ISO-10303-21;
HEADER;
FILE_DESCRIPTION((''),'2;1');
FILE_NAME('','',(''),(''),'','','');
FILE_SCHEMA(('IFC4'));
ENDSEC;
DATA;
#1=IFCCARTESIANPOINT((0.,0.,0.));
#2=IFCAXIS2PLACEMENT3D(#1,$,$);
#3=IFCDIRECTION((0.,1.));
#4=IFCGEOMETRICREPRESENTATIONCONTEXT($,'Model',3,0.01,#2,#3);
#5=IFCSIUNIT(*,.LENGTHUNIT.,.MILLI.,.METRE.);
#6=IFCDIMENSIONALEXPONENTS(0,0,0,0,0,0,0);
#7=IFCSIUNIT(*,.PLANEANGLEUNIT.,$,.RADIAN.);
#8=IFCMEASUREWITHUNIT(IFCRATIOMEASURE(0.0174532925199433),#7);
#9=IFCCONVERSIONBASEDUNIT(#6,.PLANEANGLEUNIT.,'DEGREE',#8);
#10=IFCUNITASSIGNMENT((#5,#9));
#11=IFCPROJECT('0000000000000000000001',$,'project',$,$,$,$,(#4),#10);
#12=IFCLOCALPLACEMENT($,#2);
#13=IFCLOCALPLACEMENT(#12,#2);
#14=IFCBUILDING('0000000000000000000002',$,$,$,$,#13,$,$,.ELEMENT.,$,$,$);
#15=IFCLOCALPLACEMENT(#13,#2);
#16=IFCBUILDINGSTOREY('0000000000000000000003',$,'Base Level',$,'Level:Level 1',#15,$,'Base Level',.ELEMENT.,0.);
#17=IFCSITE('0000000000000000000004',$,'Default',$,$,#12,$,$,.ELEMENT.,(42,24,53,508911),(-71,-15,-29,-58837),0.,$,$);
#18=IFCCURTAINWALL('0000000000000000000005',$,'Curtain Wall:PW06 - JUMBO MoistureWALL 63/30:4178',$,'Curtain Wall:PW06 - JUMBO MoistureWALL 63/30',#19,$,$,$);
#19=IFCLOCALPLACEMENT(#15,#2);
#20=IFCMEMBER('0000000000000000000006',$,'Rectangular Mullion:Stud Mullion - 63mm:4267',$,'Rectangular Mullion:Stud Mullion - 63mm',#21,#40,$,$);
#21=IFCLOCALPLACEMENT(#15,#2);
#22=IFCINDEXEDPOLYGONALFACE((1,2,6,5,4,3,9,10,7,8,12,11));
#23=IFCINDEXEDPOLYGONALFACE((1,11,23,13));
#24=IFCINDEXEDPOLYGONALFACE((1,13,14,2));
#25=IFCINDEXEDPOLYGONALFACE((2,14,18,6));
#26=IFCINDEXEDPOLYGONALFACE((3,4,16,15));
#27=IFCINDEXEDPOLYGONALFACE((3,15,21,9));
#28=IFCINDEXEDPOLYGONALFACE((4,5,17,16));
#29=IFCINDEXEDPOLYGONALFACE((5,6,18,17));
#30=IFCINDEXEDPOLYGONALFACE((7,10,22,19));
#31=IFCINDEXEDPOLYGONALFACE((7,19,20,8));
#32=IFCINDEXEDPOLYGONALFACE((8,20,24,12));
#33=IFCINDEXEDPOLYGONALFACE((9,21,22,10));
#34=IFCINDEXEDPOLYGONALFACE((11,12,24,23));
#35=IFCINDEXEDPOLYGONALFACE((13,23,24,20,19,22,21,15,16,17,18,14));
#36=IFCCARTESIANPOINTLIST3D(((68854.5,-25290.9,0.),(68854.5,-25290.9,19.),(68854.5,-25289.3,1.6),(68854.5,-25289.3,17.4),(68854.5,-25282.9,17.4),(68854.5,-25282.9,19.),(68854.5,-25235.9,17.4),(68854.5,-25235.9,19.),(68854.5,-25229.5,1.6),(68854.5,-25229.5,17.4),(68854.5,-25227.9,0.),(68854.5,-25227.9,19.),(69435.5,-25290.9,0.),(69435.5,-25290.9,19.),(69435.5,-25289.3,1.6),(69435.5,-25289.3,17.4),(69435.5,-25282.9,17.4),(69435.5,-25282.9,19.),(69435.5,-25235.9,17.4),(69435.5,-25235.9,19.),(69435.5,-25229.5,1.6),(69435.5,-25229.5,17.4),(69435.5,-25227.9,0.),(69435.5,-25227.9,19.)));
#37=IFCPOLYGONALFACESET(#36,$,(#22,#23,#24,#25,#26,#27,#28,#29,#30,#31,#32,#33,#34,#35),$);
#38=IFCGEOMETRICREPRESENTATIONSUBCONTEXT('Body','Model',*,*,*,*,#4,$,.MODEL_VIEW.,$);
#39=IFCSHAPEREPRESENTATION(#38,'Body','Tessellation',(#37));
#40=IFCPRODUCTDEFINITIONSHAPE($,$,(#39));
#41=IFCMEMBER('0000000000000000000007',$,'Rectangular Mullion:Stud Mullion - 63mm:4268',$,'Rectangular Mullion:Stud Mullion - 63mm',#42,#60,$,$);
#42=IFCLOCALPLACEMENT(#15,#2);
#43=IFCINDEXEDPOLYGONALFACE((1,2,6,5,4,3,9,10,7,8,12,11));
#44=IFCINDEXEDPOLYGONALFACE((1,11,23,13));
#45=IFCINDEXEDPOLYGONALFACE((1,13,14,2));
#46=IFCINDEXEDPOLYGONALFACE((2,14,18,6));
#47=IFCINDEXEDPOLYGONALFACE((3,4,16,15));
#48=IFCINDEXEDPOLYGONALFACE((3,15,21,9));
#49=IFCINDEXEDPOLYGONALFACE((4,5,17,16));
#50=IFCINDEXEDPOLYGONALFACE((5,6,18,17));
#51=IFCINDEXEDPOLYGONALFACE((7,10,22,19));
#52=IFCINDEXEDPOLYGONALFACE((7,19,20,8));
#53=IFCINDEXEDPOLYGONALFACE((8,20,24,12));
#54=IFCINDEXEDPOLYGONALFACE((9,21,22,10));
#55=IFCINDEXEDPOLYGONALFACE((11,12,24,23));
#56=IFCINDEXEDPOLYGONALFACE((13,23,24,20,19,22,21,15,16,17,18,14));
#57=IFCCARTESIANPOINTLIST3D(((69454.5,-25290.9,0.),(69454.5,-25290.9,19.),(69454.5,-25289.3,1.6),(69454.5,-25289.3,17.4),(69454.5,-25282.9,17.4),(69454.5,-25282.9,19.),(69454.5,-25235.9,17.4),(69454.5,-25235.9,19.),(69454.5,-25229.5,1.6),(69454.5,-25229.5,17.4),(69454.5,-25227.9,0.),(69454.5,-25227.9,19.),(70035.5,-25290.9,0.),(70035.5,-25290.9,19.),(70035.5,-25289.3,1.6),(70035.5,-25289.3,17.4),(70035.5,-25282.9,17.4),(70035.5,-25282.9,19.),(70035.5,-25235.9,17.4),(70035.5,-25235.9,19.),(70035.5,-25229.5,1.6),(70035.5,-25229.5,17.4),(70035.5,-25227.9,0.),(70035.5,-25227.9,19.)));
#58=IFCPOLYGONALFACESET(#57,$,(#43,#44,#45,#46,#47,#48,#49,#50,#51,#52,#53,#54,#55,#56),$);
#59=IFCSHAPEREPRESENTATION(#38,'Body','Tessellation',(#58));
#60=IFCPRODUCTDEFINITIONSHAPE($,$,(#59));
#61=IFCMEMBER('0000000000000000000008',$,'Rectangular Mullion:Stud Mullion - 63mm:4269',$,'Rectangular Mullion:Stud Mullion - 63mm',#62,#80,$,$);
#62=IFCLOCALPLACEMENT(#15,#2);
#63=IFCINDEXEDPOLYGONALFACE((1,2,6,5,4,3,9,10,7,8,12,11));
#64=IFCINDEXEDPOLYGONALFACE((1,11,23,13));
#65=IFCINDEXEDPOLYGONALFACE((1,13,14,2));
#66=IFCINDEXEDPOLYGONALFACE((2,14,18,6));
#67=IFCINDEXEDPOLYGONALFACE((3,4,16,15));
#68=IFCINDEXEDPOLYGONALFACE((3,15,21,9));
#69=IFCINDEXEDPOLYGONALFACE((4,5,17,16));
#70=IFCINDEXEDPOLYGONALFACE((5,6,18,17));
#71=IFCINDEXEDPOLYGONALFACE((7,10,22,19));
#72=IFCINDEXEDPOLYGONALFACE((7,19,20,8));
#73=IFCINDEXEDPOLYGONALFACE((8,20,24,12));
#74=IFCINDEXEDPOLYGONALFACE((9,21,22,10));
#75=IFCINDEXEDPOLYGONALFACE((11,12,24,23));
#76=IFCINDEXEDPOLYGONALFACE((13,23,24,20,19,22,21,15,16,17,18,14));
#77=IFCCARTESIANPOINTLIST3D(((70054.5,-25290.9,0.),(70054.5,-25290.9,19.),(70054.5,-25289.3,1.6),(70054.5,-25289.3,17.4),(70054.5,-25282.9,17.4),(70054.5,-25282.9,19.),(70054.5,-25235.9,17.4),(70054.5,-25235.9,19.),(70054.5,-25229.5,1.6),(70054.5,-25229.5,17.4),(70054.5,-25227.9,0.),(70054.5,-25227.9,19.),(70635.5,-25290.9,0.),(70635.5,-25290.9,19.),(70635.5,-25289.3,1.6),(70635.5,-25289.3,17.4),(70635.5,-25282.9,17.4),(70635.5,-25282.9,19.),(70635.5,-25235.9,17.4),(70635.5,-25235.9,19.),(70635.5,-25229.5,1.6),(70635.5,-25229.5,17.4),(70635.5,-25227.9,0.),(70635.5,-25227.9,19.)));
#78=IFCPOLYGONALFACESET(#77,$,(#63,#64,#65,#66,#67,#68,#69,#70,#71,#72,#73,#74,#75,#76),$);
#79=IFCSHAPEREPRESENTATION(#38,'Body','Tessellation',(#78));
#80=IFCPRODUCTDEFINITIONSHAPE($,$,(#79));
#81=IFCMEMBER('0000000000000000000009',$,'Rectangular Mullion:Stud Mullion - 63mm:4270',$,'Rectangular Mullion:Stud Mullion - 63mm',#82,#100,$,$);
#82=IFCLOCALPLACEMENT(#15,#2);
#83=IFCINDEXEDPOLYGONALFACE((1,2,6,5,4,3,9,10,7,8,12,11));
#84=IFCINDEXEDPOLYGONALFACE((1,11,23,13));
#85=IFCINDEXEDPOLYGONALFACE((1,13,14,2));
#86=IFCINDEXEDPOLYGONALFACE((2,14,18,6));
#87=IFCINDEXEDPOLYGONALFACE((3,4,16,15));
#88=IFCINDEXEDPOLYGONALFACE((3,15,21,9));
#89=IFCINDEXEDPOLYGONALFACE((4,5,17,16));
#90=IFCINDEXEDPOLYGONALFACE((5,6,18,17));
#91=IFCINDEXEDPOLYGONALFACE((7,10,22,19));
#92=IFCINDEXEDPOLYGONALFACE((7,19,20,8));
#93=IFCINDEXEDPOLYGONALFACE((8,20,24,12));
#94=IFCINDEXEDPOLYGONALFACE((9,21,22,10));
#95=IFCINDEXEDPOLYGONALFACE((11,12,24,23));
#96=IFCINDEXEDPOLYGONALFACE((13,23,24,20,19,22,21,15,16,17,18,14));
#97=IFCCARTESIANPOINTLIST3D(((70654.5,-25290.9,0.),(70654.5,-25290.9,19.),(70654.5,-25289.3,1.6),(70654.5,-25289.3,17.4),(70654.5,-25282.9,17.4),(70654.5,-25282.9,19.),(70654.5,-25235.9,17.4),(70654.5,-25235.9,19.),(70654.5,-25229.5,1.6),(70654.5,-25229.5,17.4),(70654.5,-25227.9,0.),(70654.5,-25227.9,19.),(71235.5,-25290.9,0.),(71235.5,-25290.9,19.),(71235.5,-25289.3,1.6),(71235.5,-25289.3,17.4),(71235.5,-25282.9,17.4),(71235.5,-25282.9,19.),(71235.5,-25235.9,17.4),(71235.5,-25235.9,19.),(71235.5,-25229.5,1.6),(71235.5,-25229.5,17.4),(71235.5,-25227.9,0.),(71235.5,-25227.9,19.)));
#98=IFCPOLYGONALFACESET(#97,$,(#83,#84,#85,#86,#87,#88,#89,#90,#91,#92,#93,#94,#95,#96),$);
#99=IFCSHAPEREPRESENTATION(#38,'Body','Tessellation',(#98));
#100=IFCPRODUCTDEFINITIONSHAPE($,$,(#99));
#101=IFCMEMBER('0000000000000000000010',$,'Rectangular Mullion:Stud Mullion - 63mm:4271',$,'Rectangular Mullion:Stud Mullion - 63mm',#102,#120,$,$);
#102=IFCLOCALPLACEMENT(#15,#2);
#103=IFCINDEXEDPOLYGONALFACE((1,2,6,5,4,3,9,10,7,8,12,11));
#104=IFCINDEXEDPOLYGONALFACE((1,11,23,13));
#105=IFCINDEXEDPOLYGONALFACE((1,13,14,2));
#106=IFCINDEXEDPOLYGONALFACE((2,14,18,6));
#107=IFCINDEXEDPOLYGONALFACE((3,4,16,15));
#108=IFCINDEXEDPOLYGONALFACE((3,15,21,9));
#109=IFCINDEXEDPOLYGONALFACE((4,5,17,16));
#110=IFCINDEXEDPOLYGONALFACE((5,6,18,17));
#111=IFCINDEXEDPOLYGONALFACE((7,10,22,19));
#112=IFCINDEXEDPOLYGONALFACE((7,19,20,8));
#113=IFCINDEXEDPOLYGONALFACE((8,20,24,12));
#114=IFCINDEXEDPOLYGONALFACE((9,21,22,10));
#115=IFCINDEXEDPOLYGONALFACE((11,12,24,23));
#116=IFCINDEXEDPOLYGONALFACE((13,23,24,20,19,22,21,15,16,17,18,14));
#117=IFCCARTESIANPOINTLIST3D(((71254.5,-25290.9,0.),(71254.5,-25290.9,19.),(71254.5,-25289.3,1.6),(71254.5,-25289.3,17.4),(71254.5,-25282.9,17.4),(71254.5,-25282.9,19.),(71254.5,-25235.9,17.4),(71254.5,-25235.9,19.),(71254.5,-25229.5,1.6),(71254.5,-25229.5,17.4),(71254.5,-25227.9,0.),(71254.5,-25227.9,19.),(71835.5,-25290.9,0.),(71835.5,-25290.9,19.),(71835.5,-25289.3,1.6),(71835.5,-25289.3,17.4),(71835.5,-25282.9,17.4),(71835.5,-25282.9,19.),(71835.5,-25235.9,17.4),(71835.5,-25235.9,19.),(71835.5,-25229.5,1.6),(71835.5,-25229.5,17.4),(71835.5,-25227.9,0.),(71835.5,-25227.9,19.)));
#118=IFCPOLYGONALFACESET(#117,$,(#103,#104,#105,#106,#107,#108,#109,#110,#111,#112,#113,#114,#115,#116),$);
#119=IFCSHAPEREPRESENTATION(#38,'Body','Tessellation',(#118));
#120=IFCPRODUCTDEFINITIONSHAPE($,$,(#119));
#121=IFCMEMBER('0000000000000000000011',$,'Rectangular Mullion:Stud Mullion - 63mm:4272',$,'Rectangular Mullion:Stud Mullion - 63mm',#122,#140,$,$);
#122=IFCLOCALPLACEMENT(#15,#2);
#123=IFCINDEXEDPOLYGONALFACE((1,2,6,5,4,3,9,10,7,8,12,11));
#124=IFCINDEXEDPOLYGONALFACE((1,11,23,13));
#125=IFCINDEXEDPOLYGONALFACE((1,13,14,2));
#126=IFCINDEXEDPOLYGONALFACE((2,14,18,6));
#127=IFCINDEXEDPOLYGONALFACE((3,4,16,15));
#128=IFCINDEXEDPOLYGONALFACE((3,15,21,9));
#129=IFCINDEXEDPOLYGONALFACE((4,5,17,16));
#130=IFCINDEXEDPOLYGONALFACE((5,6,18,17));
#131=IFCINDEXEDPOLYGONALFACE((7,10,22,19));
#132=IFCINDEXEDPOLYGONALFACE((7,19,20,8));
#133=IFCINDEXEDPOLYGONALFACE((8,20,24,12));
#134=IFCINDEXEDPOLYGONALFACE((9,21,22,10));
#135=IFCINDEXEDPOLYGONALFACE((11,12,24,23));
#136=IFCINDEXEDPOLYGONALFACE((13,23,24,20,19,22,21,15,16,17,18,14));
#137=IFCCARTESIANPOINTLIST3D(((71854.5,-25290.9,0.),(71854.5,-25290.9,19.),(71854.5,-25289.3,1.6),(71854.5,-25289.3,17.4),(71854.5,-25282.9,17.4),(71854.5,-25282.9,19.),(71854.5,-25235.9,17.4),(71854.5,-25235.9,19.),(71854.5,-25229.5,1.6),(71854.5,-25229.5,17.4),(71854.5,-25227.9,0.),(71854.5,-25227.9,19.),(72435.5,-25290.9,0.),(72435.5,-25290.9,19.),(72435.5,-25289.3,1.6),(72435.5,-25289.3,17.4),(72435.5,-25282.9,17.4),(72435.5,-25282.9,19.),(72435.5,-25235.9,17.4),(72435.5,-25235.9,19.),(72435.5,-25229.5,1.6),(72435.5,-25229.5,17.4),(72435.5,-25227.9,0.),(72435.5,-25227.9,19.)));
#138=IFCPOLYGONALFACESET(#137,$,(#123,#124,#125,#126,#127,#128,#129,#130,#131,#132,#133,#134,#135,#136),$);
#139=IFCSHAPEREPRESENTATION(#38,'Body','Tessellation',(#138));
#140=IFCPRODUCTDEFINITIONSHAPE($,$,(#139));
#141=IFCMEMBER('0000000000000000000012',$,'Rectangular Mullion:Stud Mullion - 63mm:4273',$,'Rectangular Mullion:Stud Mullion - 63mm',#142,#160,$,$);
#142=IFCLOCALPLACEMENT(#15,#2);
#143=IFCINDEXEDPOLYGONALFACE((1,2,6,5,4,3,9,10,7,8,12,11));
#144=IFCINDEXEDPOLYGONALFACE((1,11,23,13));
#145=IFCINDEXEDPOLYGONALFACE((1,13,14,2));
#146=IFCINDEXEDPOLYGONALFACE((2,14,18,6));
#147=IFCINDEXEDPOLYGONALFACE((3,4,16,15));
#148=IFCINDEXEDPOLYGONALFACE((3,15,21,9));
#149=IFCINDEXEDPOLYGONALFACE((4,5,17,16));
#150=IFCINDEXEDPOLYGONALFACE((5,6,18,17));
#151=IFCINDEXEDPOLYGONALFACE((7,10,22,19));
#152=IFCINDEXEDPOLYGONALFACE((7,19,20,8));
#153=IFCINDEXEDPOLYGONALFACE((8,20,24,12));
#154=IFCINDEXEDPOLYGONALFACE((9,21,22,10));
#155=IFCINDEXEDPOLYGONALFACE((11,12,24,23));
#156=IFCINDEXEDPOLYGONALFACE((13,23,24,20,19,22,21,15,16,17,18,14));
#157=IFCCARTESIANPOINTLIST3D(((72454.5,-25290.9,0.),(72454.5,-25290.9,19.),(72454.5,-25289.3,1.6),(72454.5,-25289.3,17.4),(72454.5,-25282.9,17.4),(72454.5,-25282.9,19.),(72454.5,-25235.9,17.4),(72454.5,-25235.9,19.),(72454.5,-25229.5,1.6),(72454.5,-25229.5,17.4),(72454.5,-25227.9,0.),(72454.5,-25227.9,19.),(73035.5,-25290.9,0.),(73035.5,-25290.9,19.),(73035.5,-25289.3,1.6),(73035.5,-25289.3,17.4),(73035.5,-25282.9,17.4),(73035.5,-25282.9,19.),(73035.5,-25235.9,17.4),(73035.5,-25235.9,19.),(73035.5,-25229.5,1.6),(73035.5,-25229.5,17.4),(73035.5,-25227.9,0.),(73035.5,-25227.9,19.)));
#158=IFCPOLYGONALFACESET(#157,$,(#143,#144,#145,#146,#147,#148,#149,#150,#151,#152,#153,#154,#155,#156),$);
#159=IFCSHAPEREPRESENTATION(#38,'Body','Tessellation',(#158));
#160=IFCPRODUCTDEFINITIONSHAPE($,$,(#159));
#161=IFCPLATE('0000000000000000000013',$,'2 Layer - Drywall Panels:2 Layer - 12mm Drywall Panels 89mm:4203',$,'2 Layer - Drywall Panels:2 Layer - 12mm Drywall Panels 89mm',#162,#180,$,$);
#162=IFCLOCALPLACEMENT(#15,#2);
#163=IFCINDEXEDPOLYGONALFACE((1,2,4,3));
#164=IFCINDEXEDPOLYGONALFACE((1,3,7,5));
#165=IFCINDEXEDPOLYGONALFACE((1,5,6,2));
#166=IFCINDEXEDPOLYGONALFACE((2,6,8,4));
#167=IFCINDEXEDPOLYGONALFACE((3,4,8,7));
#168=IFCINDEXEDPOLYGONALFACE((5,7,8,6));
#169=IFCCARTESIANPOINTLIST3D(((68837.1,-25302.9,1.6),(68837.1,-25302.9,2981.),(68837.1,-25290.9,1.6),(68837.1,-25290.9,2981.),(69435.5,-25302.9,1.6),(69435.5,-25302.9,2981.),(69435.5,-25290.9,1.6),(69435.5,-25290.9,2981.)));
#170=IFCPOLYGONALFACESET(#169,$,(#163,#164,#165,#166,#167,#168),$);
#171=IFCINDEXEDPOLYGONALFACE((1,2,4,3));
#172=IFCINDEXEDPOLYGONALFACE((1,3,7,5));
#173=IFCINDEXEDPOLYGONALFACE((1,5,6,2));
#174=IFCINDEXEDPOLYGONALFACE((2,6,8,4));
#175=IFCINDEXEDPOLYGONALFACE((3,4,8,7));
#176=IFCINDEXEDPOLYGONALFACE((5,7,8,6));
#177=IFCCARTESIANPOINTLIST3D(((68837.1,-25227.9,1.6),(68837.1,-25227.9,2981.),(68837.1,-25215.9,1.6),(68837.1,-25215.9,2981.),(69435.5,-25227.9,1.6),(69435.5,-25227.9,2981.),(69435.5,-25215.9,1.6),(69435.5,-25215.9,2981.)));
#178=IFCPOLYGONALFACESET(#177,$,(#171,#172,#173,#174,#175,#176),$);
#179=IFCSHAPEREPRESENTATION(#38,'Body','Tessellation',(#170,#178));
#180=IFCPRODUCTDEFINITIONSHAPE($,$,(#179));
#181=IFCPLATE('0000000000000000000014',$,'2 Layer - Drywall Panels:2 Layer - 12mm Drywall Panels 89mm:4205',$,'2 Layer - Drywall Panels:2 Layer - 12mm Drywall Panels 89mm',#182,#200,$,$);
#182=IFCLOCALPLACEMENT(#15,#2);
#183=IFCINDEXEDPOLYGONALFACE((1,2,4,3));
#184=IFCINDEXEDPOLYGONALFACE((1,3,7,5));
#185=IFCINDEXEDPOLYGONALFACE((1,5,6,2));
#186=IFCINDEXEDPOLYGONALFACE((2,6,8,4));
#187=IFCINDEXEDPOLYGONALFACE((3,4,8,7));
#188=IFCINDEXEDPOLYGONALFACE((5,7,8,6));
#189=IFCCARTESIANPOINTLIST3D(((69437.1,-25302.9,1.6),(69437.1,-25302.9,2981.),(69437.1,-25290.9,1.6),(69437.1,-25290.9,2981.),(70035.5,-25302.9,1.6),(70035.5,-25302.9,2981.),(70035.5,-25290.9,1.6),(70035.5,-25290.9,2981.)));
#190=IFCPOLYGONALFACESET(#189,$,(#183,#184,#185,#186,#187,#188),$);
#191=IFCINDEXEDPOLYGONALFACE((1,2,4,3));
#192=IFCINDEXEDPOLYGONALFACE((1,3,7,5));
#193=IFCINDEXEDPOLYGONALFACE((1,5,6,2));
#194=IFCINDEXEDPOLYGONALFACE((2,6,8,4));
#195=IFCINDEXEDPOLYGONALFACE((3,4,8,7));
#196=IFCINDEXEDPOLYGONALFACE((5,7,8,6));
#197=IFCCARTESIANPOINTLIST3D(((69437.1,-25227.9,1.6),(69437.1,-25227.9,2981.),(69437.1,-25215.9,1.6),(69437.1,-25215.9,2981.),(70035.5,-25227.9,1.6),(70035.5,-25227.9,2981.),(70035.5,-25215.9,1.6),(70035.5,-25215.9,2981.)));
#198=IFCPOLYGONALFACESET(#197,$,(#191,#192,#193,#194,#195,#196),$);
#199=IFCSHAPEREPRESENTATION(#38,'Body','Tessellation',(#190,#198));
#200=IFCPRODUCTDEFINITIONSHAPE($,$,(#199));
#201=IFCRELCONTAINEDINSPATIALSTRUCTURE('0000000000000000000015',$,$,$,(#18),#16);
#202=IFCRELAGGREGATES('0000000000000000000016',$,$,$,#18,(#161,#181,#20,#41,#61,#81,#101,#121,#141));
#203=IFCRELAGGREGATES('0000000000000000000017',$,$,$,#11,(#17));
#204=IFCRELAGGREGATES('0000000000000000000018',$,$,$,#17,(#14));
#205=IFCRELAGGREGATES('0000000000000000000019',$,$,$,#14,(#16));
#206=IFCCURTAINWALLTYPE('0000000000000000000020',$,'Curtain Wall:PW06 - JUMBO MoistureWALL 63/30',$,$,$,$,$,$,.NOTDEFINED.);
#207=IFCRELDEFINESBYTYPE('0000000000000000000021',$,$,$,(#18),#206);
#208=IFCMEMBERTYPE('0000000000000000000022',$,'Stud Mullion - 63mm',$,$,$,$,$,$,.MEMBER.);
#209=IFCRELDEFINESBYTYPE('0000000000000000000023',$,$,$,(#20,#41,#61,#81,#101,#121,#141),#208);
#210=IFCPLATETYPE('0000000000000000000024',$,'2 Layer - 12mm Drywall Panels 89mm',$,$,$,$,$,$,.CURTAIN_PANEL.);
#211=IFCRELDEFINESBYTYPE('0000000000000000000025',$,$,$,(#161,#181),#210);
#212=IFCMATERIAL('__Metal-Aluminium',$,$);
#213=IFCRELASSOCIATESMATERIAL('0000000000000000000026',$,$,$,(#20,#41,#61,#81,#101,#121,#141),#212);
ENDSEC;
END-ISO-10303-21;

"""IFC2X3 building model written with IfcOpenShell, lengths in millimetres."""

from ifc_helpers import new_model, entity, si_unit, converted_unit, direction, frame, frame_2d, origin, place, context, subcontext, project, spatial, polyline, rectangle, outline, extrude, source, transform, mapped, material, type_object, type_shapes, element, aggregate, save


model = new_model("IFC2X3")

# Units and contexts
model_context = context("Model", 3, precision=0.01, world=origin(), true_north=direction((0.0, 1.0)))
body_context = subcontext(model_context, "Body", "Model", "MODEL_VIEW")
ifc_project = project(units=[si_unit("LENGTHUNIT", "METRE", prefix="MILLI"), converted_unit("PLANEANGLEUNIT", "DEGREE", entity("IfcRatioMeasure", 0.0174532925199433), si_unit("PLANEANGLEUNIT", "RADIAN"), dimensions=[0, 0, 0, 0, 0, 0, 0])], contexts=[model_context])

# Site, building, storey
site_placement = place(None, origin())
site = spatial("IfcSite", under=ifc_project, at=site_placement, Name="Default", CompositionType="ELEMENT", RefLatitude=(42, 24, 53, 508911), RefLongitude=(-71, -15, -29, -58837), RefElevation=0.0)
building_placement = place(site_placement, origin())
building = spatial("IfcBuilding", under=site, at=building_placement, CompositionType="ELEMENT")
storey_placement = place(building_placement, origin())
storey = spatial("IfcBuildingStorey", under=building, at=storey_placement, Name="Base Level", ObjectType="Level:Level 1", LongName="Base Level", CompositionType="ELEMENT", Elevation=0.0)

# Curtain wall, members, plates
curtain_wall_type = type_object("IfcCurtainWallType", Name="Curtain Wall:PW06 - JUMBO MoistureWALL 63/30", PredefinedType="NOTDEFINED")
curtain_wall_placement = place(building_placement, origin())
curtain_wall = element("IfcCurtainWall", 1, at=curtain_wall_placement, inside=storey, type_object=curtain_wall_type, Name="Curtain Wall:PW06 - JUMBO MoistureWALL 63/30:4178", ObjectType="Curtain Wall:PW06 - JUMBO MoistureWALL 63/30")
ifc_material = material(Name="__Metal-Aluminium")
member_type_1 = type_object("IfcMemberType", Name="Stud Mullion - 63mm", PredefinedType="MEMBER")
shared_shape_1 = source(origin(), body_context, "Body", "SweptSolid", [
    extrude(outline(polyline([(23.5, -6.6), (31.5, -6.6), (31.5, 12.4), (-31.5, 12.4), (-31.5, -6.6), (-23.5, -6.6), (-23.5, -5.0), (-29.9, -5.0), (-29.9, 10.8), (29.9, 10.8), (29.9, -5.0), (23.5, -5.0), (23.5, -6.6)])), frame((-12.4, 0.0, -581.0), z_axis=(0.0, 0.0, 1.0), x_axis=(0.0, -1.0, 0.0)), (0.0, 0.0, 1.0), 581.0),
])
type_shapes(member_type_1, [shared_shape_1])
member_1_placement = place(building_placement, frame((68854.5, -25259.4, 0.0), z_axis=(-1.0, 0.0, 0.0), x_axis=(0.0, 0.0, -1.0)))
member_1 = element("IfcMember", 2, at=member_1_placement, type_object=member_type_1, material=ifc_material, Name="Rectangular Mullion:Stud Mullion - 63mm:4267", ObjectType="Rectangular Mullion:Stud Mullion - 63mm", context=body_context, shape_type="MappedRepresentation", body=[
    mapped(shared_shape_1, transform((0.0, 0.0, 0.0), scale=1.0)),
])
member_2_placement = place(building_placement, frame((69454.5, -25259.4, 0.0), z_axis=(-1.0, 0.0, 0.0), x_axis=(0.0, 0.0, -1.0)))
member_2 = element("IfcMember", 3, at=member_2_placement, type_object=member_type_1, material=ifc_material, Name="Rectangular Mullion:Stud Mullion - 63mm:4268", ObjectType="Rectangular Mullion:Stud Mullion - 63mm", context=body_context, shape_type="MappedRepresentation", body=[
    mapped(shared_shape_1, transform((0.0, 0.0, 0.0), scale=1.0)),
])
member_3_placement = place(building_placement, frame((70054.5, -25259.4, 0.0), z_axis=(-1.0, 0.0, 0.0), x_axis=(0.0, 0.0, -1.0)))
member_3 = element("IfcMember", 4, at=member_3_placement, type_object=member_type_1, material=ifc_material, Name="Rectangular Mullion:Stud Mullion - 63mm:4269", ObjectType="Rectangular Mullion:Stud Mullion - 63mm", context=body_context, shape_type="MappedRepresentation", body=[
    mapped(shared_shape_1, transform((0.0, 0.0, 0.0), scale=1.0)),
])
member_4_placement = place(building_placement, frame((70654.5, -25259.4, 0.0), z_axis=(-1.0, 0.0, 0.0), x_axis=(0.0, 0.0, -1.0)))
member_4 = element("IfcMember", 5, at=member_4_placement, type_object=member_type_1, material=ifc_material, Name="Rectangular Mullion:Stud Mullion - 63mm:4270", ObjectType="Rectangular Mullion:Stud Mullion - 63mm", context=body_context, shape_type="MappedRepresentation", body=[
    mapped(shared_shape_1, transform((0.0, 0.0, 0.0), scale=1.0)),
])
member_5_placement = place(building_placement, frame((71254.5, -25259.4, 0.0), z_axis=(-1.0, 0.0, 0.0), x_axis=(0.0, 0.0, -1.0)))
member_5 = element("IfcMember", 6, at=member_5_placement, type_object=member_type_1, material=ifc_material, Name="Rectangular Mullion:Stud Mullion - 63mm:4271", ObjectType="Rectangular Mullion:Stud Mullion - 63mm", context=body_context, shape_type="MappedRepresentation", body=[
    mapped(shared_shape_1, transform((0.0, 0.0, 0.0), scale=1.0)),
])
member_6_placement = place(building_placement, frame((71854.5, -25259.4, 0.0), z_axis=(-1.0, 0.0, 0.0), x_axis=(0.0, 0.0, -1.0)))
member_6 = element("IfcMember", 7, at=member_6_placement, type_object=member_type_1, material=ifc_material, Name="Rectangular Mullion:Stud Mullion - 63mm:4272", ObjectType="Rectangular Mullion:Stud Mullion - 63mm", context=body_context, shape_type="MappedRepresentation", body=[
    mapped(shared_shape_1, transform((0.0, 0.0, 0.0), scale=1.0)),
])
member_7_placement = place(building_placement, frame((72454.5, -25259.4, 0.0), z_axis=(-1.0, 0.0, 0.0), x_axis=(0.0, 0.0, -1.0)))
member_7 = element("IfcMember", 8, at=member_7_placement, type_object=member_type_1, material=ifc_material, Name="Rectangular Mullion:Stud Mullion - 63mm:4273", ObjectType="Rectangular Mullion:Stud Mullion - 63mm", context=body_context, shape_type="MappedRepresentation", body=[
    mapped(shared_shape_1, transform((0.0, 0.0, 0.0), scale=1.0)),
])
plate_type = type_object("IfcPlateType", Name="2 Layer - 12mm Drywall Panels 89mm", PredefinedType="CURTAIN_PANEL")
shared_shape_2 = source(origin(), body_context, "Body", "SweptSolid", [
    extrude(rectangle(XDim=598.4, YDim=12.0, at=frame_2d((0.0, 0.0), x_axis=(1.0, 0.0))), frame((0.0, -37.5, 0.0), z_axis=(0.0, 0.0, 1.0), x_axis=(-1.0, 0.0, 0.0)), (0.0, 0.0, 1.0), 2979.4),
    extrude(rectangle(XDim=12.0, YDim=598.4, at=frame_2d((0.0, 0.0), x_axis=(1.0, 0.0))), frame((0.0, 37.5, 0.0), z_axis=(0.0, 0.0, 1.0), x_axis=(0.0, 1.0, 0.0)), (0.0, 0.0, 1.0), 2979.4),
])
type_shapes(plate_type, [shared_shape_2])
plate_1_placement = place(curtain_wall_placement, frame((69136.3, -25259.4, 1.6)))
plate_1 = element("IfcPlate", 9, at=plate_1_placement, type_object=plate_type, Name="2 Layer - Drywall Panels:2 Layer - 12mm Drywall Panels 89mm:4203", ObjectType="2 Layer - Drywall Panels:2 Layer - 12mm Drywall Panels 89mm", context=body_context, shape_type="MappedRepresentation", body=[
    mapped(shared_shape_2, transform((0.0, 0.0, 0.0), scale=1.0)),
])
plate_2_placement = place(curtain_wall_placement, frame((69736.3, -25259.4, 1.6)))
plate_2 = element("IfcPlate", 10, at=plate_2_placement, type_object=plate_type, Name="2 Layer - Drywall Panels:2 Layer - 12mm Drywall Panels 89mm:4205", ObjectType="2 Layer - Drywall Panels:2 Layer - 12mm Drywall Panels 89mm", context=body_context, shape_type="MappedRepresentation", body=[
    mapped(shared_shape_2, transform((0.0, 0.0, 0.0), scale=1.0)),
])
aggregate(curtain_wall, [plate_1, plate_2, member_1, member_2, member_3, member_4, member_5, member_6, member_7])

save(model, "model.ifc")
